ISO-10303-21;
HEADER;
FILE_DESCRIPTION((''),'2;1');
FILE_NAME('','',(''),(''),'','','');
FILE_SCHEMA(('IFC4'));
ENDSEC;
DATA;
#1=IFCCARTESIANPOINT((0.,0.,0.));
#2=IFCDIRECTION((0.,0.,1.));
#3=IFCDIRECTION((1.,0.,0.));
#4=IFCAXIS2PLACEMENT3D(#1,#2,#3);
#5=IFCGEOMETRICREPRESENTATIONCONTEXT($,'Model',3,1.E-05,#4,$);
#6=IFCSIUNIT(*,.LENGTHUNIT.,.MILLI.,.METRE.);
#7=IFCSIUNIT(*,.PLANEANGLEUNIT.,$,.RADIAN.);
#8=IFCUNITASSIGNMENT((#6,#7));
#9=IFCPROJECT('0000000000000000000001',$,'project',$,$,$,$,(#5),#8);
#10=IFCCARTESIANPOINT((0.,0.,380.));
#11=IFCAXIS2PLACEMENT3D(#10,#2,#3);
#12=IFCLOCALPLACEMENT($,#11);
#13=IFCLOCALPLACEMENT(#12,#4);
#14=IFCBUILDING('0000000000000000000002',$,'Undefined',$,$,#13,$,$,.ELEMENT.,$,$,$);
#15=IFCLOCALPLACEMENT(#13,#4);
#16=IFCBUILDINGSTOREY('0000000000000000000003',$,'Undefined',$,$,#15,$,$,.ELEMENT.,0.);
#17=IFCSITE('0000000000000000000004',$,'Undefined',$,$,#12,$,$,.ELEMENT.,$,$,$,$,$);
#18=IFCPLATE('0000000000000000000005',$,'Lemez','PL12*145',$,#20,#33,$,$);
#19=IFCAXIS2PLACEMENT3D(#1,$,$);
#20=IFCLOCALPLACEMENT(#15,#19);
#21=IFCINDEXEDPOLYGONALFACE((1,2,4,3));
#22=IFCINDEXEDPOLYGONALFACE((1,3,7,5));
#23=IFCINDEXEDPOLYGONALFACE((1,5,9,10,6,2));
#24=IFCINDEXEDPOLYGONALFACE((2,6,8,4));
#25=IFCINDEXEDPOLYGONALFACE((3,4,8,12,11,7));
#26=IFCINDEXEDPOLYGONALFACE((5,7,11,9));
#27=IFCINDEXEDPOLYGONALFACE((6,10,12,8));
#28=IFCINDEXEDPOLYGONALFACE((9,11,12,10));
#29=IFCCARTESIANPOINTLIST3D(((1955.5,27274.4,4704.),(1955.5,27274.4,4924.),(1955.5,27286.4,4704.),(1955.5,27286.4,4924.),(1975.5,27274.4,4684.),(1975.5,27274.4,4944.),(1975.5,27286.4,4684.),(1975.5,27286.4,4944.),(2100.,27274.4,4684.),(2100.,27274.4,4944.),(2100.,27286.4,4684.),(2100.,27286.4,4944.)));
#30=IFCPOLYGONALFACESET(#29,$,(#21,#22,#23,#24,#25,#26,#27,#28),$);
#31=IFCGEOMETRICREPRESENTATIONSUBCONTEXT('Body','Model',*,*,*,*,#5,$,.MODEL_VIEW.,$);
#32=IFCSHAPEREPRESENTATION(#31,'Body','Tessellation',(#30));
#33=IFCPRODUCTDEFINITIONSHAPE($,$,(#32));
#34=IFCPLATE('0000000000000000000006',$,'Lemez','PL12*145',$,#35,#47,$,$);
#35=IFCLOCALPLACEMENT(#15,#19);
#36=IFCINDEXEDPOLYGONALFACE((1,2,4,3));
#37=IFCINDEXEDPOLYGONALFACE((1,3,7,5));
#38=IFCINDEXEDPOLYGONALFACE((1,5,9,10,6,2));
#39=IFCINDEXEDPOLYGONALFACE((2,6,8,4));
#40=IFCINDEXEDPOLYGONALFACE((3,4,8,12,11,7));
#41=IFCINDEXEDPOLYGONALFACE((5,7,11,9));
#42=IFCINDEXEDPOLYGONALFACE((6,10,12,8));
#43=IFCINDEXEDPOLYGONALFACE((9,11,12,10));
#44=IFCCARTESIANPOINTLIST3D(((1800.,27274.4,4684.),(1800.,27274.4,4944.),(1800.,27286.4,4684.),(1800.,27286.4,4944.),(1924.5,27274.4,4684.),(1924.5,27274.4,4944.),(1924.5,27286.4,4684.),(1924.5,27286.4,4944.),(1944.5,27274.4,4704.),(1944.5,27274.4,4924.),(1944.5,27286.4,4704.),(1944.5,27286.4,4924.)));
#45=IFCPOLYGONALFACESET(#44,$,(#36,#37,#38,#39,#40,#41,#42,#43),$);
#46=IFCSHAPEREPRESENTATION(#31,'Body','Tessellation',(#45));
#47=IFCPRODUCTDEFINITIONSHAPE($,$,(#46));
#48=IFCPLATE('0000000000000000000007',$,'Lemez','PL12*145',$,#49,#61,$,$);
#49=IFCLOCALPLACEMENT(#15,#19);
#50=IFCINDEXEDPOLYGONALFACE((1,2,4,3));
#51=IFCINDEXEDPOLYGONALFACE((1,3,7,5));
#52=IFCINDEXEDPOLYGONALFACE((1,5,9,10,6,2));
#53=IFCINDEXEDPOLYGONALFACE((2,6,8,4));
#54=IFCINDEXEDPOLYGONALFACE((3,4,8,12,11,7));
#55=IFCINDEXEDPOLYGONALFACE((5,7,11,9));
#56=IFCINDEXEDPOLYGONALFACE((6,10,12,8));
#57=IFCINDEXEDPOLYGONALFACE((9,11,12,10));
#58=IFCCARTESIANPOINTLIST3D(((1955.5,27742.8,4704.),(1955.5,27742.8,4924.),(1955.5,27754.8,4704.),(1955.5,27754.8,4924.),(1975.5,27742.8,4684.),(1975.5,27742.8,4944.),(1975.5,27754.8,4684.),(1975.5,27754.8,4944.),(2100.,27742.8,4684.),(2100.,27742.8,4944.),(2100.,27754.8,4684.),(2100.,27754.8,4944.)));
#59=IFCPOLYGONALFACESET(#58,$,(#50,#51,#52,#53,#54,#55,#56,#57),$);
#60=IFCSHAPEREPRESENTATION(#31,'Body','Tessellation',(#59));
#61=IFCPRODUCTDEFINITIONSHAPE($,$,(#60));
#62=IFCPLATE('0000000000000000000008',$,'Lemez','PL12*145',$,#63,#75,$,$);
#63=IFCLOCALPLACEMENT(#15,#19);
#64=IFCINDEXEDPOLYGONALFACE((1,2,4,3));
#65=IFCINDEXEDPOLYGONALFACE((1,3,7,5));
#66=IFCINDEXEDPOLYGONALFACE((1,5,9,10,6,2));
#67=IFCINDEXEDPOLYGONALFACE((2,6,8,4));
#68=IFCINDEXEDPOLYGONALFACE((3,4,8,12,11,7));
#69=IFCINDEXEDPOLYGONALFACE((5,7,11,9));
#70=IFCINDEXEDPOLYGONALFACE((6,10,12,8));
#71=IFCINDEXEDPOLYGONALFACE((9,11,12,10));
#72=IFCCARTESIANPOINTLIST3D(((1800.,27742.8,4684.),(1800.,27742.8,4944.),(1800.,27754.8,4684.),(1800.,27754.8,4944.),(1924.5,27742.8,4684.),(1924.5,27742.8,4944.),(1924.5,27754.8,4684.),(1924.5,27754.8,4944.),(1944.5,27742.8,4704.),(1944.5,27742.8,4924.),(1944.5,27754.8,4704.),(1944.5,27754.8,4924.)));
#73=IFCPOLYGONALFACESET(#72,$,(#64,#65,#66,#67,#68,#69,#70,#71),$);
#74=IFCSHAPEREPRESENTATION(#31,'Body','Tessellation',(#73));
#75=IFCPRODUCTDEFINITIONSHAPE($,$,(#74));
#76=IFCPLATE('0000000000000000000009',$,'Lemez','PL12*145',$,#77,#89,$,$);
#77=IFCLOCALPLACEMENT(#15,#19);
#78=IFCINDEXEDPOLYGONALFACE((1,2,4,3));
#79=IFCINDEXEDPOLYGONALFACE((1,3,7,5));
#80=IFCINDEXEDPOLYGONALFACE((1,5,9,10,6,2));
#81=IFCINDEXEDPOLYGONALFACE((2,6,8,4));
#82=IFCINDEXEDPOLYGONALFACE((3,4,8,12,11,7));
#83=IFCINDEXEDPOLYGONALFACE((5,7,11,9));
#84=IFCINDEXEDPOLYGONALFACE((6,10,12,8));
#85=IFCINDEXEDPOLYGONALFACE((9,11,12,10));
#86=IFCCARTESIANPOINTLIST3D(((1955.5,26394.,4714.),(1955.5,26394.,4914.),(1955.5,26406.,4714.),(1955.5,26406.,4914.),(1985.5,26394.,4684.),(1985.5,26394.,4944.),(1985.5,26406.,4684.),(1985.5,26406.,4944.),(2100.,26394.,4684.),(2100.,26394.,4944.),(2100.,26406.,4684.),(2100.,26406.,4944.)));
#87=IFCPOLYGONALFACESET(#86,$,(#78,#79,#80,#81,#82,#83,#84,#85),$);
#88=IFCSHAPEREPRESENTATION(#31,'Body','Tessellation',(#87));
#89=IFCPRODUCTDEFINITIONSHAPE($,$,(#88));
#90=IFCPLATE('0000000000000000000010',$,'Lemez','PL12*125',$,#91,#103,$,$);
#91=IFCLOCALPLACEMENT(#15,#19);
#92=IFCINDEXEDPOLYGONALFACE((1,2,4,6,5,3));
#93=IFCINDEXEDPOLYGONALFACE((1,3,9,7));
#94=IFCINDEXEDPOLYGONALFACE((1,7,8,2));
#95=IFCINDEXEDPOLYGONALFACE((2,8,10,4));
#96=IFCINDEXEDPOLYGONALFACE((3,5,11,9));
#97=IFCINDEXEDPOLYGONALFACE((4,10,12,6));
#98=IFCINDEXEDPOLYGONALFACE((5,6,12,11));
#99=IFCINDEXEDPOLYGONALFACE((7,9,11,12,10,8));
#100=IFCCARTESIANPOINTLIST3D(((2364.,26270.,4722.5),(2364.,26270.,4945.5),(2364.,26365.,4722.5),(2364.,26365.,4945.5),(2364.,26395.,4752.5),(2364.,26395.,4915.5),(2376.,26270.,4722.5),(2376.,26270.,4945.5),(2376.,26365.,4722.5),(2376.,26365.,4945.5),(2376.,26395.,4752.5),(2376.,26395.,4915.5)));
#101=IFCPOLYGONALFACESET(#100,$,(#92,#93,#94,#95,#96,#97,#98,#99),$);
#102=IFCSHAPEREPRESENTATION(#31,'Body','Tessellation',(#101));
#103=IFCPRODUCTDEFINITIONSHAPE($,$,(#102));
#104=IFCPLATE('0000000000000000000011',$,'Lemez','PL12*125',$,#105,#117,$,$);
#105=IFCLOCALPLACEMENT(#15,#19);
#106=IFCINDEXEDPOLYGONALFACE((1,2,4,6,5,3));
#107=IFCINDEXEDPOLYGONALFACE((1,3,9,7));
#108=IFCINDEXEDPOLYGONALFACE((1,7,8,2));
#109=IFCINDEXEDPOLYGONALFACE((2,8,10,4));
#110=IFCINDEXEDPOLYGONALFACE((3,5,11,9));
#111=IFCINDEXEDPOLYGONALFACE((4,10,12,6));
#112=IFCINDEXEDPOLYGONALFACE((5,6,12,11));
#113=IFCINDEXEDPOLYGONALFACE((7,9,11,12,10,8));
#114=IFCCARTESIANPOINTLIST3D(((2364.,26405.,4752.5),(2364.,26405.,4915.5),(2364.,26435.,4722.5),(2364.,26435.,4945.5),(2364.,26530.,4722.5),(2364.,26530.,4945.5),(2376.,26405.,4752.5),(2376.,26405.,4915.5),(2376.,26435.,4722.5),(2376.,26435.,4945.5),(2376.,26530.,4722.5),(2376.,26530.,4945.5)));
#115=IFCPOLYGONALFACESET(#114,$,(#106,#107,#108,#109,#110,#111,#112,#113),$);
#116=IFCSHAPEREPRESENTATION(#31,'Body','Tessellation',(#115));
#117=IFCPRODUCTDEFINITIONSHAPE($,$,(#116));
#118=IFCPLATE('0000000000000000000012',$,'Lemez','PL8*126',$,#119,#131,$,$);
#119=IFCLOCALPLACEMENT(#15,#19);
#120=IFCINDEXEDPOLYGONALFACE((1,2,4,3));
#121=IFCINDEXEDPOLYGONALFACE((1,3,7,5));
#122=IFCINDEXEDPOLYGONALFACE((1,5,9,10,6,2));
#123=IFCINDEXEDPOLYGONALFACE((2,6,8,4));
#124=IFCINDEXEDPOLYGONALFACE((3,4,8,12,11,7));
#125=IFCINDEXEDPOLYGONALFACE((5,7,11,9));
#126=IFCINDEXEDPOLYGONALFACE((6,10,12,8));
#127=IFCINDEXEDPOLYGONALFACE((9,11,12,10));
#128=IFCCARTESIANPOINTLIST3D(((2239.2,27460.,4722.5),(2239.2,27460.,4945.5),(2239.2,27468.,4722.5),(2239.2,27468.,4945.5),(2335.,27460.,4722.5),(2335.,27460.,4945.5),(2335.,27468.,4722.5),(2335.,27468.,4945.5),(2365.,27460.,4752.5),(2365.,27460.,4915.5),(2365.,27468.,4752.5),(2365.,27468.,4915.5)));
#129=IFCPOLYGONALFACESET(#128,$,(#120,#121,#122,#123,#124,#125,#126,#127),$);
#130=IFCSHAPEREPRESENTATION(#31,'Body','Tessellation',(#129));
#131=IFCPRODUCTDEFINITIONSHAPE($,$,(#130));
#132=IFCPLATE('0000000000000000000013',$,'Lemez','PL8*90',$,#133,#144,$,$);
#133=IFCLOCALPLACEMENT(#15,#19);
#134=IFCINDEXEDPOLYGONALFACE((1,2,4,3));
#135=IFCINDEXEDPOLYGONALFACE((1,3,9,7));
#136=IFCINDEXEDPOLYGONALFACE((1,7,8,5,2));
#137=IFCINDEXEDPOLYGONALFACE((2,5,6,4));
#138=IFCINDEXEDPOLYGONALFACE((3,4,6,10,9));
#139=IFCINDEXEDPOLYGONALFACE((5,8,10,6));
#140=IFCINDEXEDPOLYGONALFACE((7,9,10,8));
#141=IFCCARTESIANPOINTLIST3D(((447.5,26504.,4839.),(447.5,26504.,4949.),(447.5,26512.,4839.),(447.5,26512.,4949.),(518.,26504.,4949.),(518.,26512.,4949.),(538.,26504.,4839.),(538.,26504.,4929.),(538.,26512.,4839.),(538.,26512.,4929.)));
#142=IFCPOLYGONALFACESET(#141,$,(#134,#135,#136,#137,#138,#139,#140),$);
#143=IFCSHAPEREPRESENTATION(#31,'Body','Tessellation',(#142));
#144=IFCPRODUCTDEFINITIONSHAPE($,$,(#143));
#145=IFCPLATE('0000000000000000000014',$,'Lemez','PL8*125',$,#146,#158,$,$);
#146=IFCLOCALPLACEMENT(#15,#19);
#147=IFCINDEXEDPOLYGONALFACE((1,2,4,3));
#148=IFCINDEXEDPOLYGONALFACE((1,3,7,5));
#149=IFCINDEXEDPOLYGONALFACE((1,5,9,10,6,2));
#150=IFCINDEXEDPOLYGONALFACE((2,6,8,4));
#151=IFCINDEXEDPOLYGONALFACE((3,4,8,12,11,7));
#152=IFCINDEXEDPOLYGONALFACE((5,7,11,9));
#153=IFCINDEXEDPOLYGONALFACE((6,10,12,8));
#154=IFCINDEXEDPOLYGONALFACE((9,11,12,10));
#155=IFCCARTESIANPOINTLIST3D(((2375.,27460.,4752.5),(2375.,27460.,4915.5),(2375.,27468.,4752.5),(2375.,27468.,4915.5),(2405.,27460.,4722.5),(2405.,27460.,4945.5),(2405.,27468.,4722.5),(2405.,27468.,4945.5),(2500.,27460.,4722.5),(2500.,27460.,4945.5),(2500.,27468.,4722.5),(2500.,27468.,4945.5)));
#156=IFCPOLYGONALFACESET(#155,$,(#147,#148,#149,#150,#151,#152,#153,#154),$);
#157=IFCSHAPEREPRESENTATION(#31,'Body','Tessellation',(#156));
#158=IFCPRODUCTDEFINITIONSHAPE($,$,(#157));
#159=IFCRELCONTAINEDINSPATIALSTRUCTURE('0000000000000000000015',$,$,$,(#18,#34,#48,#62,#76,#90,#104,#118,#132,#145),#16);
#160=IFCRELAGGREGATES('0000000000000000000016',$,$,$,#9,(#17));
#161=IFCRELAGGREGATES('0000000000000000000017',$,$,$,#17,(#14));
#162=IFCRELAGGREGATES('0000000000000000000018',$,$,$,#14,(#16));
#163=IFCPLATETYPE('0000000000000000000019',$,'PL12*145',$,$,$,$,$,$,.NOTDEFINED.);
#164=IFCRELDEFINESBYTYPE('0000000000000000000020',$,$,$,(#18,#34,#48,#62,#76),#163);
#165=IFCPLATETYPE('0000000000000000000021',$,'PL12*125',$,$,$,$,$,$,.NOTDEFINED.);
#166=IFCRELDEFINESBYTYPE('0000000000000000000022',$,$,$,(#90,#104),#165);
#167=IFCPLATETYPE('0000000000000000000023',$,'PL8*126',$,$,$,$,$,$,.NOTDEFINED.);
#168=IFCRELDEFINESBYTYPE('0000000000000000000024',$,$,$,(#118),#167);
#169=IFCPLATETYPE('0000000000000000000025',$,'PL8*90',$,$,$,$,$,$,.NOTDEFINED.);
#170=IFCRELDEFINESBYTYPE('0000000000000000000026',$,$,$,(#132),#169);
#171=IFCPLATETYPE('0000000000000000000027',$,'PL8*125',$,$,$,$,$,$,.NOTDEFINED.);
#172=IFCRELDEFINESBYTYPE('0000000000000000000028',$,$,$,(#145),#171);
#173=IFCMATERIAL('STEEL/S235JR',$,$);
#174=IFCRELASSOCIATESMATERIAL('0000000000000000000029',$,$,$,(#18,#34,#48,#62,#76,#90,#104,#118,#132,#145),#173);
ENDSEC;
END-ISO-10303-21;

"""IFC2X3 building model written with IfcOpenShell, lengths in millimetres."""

from ifc_helpers import new_model, si_unit, frame, origin_with_axes, place, context, subcontext, project, spatial, polyline, outline, extrude, material, type_object, element, save


model = new_model("IFC2X3")

# Units and contexts
model_context = context("Model", 3, precision=1e-05, world=origin_with_axes())
body_context = subcontext(model_context, "Body", "Model", "MODEL_VIEW")
ifc_project = project(units=[si_unit("LENGTHUNIT", "METRE", prefix="MILLI"), si_unit("PLANEANGLEUNIT", "RADIAN")], contexts=[model_context])

# Site, building, storey
site_placement = place(None, frame((0.0, 0.0, 380.0), z_axis=(0.0, 0.0, 1.0), x_axis=(1.0, 0.0, 0.0)))
site = spatial("IfcSite", under=ifc_project, at=site_placement, Name="Undefined", CompositionType="ELEMENT")
building_placement = place(site_placement, origin_with_axes())
building = spatial("IfcBuilding", under=site, at=building_placement, Name="Undefined", CompositionType="ELEMENT")
storey_placement = place(building_placement, origin_with_axes())
storey = spatial("IfcBuildingStorey", under=building, at=storey_placement, Name="Undefined", CompositionType="ELEMENT", Elevation=0.0)

# Shared definitions
ifc_material = material(Name="STEEL/S235JR")

# Plates
plate_type_1 = type_object("IfcPlateType", Name="PL12*145", PredefinedType="NOTDEFINED")
plate_1_placement = place(storey_placement, frame((2100.0, 27280.4, 4684.0), z_axis=(0.0, 1.0, 0.0), x_axis=(-1.0, 0.0, 0.0)))
element("IfcPlate", 1, at=plate_1_placement, inside=storey, type_object=plate_type_1, material=ifc_material, Name="Lemez", Description="PL12*145", context=body_context, shape_type="SweptSolid", body=[
    extrude(outline(polyline([(0.0, 0.0), (124.5, 0.0), (144.5, 20.0), (144.5, 240.0), (124.5, 260.0), (0.0, 260.0), (0.0, 0.0)])), frame((0.0, 0.0, -6.0), z_axis=(0.0, 0.0, 1.0), x_axis=(1.0, 0.0, 0.0)), (0.0, 0.0, 1.0), 12.0),
])
plate_2_placement = place(storey_placement, frame((1800.0, 27280.4, 4684.0), z_axis=(0.0, 1.0, 0.0), x_axis=(0.0, 0.0, 1.0)))
element("IfcPlate", 2, at=plate_2_placement, inside=storey, type_object=plate_type_1, material=ifc_material, Name="Lemez", Description="PL12*145", context=body_context, shape_type="SweptSolid", body=[
    extrude(outline(polyline([(0.0, 0.0), (260.0, 0.0), (260.0, 124.5), (240.0, 144.5), (20.0, 144.5), (0.0, 124.5), (0.0, 0.0)])), frame((0.0, 0.0, -6.0), z_axis=(0.0, 0.0, 1.0), x_axis=(1.0, 0.0, 0.0)), (0.0, 0.0, 1.0), 12.0),
])
plate_3_placement = place(storey_placement, frame((2100.0, 27748.8, 4684.0), z_axis=(0.0, 1.0, 0.0), x_axis=(-1.0, 0.0, 0.0)))
element("IfcPlate", 3, at=plate_3_placement, inside=storey, type_object=plate_type_1, material=ifc_material, Name="Lemez", Description="PL12*145", context=body_context, shape_type="SweptSolid", body=[
    extrude(outline(polyline([(0.0, 0.0), (124.5, 0.0), (144.5, 20.0), (144.5, 240.0), (124.5, 260.0), (0.0, 260.0), (0.0, 0.0)])), frame((0.0, 0.0, -6.0), z_axis=(0.0, 0.0, 1.0), x_axis=(1.0, 0.0, 0.0)), (0.0, 0.0, 1.0), 12.0),
])
plate_4_placement = place(storey_placement, frame((1800.0, 27748.8, 4684.0), z_axis=(0.0, 1.0, 0.0), x_axis=(0.0, 0.0, 1.0)))
element("IfcPlate", 4, at=plate_4_placement, inside=storey, type_object=plate_type_1, material=ifc_material, Name="Lemez", Description="PL12*145", context=body_context, shape_type="SweptSolid", body=[
    extrude(outline(polyline([(0.0, 0.0), (260.0, 0.0), (260.0, 124.5), (240.0, 144.5), (20.0, 144.5), (0.0, 124.5), (0.0, 0.0)])), frame((0.0, 0.0, -6.0), z_axis=(0.0, 0.0, 1.0), x_axis=(1.0, 0.0, 0.0)), (0.0, 0.0, 1.0), 12.0),
])
plate_5_placement = place(storey_placement, frame((1955.5, 26400.0, 4684.0), z_axis=(0.0, -1.0, 0.0), x_axis=(1.0, 0.0, 0.0)))
element("IfcPlate", 5, at=plate_5_placement, inside=storey, type_object=plate_type_1, material=ifc_material, Name="Lemez", Description="PL12*145", context=body_context, shape_type="SweptSolid", body=[
    extrude(outline(polyline([(0.0, 30.0), (30.0, 0.0), (144.5, 0.0), (144.5, 260.0), (30.0, 260.0), (0.0, 230.0), (0.0, 30.0)])), frame((0.0, 0.0, -6.0), z_axis=(0.0, 0.0, 1.0), x_axis=(1.0, 0.0, 0.0)), (0.0, 0.0, 1.0), 12.0),
])
plate_type_2 = type_object("IfcPlateType", Name="PL12*125", PredefinedType="NOTDEFINED")
for number, where, z_axis, x_axis, name in (
    (6, (2370.0, 26395.0, 4722.5), (-1.0, 0.0, 0.0), (0.0, -1.0, 0.0), "Lemez"),
    (7, (2370.0, 26405.0, 4722.5), (1.0, 0.0, 0.0), (0.0, 1.0, 0.0), "Lemez"),
):
    element("IfcPlate", number, at=place(storey_placement, frame(where, z_axis=z_axis, x_axis=x_axis)), inside=storey, type_object=plate_type_2, material=ifc_material, Name=name, Description="PL12*125", context=body_context, shape_type="SweptSolid", body=[
        extrude(outline(polyline([(0.0, 30.0), (30.0, 0.0), (125.0, 0.0), (125.0, 223.0), (30.0, 223.0), (0.0, 193.0), (0.0, 30.0)])), frame((0.0, 0.0, -6.0), z_axis=(0.0, 0.0, 1.0), x_axis=(1.0, 0.0, 0.0)), (0.0, 0.0, 1.0), 12.0),
    ])
plate_type_3 = type_object("IfcPlateType", Name="PL8*126", PredefinedType="NOTDEFINED")
plate_6_placement = place(storey_placement, frame((2365.0, 27464.0, 4722.5), z_axis=(0.0, 1.0, 0.0), x_axis=(-1.0, 0.0, 0.0)))
element("IfcPlate", 8, at=plate_6_placement, inside=storey, type_object=plate_type_3, material=ifc_material, Name="Lemez", Description="PL8*126", context=body_context, shape_type="SweptSolid", body=[
    extrude(outline(polyline([(0.0, 30.0), (30.0, 0.0), (125.8, 0.0), (125.8, 223.0), (30.0, 223.0), (0.0, 193.0), (0.0, 30.0)])), frame((0.0, 0.0, -4.0), z_axis=(0.0, 0.0, 1.0), x_axis=(1.0, 0.0, 0.0)), (0.0, 0.0, 1.0), 8.0),
])
plate_type_4 = type_object("IfcPlateType", Name="PL8*90", PredefinedType="NOTDEFINED")
plate_7_placement = place(storey_placement, frame((538.0, 26508.0, 4839.0), z_axis=(0.0, 1.0, 0.0), x_axis=(-1.0, 0.0, 0.0)))
element("IfcPlate", 9, at=plate_7_placement, inside=storey, type_object=plate_type_4, material=ifc_material, Name="Lemez", Description="PL8*90", context=body_context, shape_type="SweptSolid", body=[
    extrude(outline(polyline([(0.0, 0.0), (90.5, 0.0), (90.5, 110.0), (20.0, 110.0), (0.0, 90.0), (0.0, 0.0)])), frame((0.0, 0.0, -4.0), z_axis=(0.0, 0.0, 1.0), x_axis=(1.0, 0.0, 0.0)), (0.0, 0.0, 1.0), 8.0),
])
plate_type_5 = type_object("IfcPlateType", Name="PL8*125", PredefinedType="NOTDEFINED")
plate_8_placement = place(storey_placement, frame((2375.0, 27464.0, 4722.5), z_axis=(0.0, -1.0, 0.0), x_axis=(1.0, 0.0, 0.0)))
element("IfcPlate", 10, at=plate_8_placement, inside=storey, type_object=plate_type_5, material=ifc_material, Name="Lemez", Description="PL8*125", context=body_context, shape_type="SweptSolid", body=[
    extrude(outline(polyline([(0.0, 30.0), (30.0, 0.0), (125.0, 0.0), (125.0, 223.0), (30.0, 223.0), (0.0, 193.0), (0.0, 30.0)])), frame((0.0, 0.0, -4.0), z_axis=(0.0, 0.0, 1.0), x_axis=(1.0, 0.0, 0.0)), (0.0, 0.0, 1.0), 8.0),
])

save(model, "model.ifc")
